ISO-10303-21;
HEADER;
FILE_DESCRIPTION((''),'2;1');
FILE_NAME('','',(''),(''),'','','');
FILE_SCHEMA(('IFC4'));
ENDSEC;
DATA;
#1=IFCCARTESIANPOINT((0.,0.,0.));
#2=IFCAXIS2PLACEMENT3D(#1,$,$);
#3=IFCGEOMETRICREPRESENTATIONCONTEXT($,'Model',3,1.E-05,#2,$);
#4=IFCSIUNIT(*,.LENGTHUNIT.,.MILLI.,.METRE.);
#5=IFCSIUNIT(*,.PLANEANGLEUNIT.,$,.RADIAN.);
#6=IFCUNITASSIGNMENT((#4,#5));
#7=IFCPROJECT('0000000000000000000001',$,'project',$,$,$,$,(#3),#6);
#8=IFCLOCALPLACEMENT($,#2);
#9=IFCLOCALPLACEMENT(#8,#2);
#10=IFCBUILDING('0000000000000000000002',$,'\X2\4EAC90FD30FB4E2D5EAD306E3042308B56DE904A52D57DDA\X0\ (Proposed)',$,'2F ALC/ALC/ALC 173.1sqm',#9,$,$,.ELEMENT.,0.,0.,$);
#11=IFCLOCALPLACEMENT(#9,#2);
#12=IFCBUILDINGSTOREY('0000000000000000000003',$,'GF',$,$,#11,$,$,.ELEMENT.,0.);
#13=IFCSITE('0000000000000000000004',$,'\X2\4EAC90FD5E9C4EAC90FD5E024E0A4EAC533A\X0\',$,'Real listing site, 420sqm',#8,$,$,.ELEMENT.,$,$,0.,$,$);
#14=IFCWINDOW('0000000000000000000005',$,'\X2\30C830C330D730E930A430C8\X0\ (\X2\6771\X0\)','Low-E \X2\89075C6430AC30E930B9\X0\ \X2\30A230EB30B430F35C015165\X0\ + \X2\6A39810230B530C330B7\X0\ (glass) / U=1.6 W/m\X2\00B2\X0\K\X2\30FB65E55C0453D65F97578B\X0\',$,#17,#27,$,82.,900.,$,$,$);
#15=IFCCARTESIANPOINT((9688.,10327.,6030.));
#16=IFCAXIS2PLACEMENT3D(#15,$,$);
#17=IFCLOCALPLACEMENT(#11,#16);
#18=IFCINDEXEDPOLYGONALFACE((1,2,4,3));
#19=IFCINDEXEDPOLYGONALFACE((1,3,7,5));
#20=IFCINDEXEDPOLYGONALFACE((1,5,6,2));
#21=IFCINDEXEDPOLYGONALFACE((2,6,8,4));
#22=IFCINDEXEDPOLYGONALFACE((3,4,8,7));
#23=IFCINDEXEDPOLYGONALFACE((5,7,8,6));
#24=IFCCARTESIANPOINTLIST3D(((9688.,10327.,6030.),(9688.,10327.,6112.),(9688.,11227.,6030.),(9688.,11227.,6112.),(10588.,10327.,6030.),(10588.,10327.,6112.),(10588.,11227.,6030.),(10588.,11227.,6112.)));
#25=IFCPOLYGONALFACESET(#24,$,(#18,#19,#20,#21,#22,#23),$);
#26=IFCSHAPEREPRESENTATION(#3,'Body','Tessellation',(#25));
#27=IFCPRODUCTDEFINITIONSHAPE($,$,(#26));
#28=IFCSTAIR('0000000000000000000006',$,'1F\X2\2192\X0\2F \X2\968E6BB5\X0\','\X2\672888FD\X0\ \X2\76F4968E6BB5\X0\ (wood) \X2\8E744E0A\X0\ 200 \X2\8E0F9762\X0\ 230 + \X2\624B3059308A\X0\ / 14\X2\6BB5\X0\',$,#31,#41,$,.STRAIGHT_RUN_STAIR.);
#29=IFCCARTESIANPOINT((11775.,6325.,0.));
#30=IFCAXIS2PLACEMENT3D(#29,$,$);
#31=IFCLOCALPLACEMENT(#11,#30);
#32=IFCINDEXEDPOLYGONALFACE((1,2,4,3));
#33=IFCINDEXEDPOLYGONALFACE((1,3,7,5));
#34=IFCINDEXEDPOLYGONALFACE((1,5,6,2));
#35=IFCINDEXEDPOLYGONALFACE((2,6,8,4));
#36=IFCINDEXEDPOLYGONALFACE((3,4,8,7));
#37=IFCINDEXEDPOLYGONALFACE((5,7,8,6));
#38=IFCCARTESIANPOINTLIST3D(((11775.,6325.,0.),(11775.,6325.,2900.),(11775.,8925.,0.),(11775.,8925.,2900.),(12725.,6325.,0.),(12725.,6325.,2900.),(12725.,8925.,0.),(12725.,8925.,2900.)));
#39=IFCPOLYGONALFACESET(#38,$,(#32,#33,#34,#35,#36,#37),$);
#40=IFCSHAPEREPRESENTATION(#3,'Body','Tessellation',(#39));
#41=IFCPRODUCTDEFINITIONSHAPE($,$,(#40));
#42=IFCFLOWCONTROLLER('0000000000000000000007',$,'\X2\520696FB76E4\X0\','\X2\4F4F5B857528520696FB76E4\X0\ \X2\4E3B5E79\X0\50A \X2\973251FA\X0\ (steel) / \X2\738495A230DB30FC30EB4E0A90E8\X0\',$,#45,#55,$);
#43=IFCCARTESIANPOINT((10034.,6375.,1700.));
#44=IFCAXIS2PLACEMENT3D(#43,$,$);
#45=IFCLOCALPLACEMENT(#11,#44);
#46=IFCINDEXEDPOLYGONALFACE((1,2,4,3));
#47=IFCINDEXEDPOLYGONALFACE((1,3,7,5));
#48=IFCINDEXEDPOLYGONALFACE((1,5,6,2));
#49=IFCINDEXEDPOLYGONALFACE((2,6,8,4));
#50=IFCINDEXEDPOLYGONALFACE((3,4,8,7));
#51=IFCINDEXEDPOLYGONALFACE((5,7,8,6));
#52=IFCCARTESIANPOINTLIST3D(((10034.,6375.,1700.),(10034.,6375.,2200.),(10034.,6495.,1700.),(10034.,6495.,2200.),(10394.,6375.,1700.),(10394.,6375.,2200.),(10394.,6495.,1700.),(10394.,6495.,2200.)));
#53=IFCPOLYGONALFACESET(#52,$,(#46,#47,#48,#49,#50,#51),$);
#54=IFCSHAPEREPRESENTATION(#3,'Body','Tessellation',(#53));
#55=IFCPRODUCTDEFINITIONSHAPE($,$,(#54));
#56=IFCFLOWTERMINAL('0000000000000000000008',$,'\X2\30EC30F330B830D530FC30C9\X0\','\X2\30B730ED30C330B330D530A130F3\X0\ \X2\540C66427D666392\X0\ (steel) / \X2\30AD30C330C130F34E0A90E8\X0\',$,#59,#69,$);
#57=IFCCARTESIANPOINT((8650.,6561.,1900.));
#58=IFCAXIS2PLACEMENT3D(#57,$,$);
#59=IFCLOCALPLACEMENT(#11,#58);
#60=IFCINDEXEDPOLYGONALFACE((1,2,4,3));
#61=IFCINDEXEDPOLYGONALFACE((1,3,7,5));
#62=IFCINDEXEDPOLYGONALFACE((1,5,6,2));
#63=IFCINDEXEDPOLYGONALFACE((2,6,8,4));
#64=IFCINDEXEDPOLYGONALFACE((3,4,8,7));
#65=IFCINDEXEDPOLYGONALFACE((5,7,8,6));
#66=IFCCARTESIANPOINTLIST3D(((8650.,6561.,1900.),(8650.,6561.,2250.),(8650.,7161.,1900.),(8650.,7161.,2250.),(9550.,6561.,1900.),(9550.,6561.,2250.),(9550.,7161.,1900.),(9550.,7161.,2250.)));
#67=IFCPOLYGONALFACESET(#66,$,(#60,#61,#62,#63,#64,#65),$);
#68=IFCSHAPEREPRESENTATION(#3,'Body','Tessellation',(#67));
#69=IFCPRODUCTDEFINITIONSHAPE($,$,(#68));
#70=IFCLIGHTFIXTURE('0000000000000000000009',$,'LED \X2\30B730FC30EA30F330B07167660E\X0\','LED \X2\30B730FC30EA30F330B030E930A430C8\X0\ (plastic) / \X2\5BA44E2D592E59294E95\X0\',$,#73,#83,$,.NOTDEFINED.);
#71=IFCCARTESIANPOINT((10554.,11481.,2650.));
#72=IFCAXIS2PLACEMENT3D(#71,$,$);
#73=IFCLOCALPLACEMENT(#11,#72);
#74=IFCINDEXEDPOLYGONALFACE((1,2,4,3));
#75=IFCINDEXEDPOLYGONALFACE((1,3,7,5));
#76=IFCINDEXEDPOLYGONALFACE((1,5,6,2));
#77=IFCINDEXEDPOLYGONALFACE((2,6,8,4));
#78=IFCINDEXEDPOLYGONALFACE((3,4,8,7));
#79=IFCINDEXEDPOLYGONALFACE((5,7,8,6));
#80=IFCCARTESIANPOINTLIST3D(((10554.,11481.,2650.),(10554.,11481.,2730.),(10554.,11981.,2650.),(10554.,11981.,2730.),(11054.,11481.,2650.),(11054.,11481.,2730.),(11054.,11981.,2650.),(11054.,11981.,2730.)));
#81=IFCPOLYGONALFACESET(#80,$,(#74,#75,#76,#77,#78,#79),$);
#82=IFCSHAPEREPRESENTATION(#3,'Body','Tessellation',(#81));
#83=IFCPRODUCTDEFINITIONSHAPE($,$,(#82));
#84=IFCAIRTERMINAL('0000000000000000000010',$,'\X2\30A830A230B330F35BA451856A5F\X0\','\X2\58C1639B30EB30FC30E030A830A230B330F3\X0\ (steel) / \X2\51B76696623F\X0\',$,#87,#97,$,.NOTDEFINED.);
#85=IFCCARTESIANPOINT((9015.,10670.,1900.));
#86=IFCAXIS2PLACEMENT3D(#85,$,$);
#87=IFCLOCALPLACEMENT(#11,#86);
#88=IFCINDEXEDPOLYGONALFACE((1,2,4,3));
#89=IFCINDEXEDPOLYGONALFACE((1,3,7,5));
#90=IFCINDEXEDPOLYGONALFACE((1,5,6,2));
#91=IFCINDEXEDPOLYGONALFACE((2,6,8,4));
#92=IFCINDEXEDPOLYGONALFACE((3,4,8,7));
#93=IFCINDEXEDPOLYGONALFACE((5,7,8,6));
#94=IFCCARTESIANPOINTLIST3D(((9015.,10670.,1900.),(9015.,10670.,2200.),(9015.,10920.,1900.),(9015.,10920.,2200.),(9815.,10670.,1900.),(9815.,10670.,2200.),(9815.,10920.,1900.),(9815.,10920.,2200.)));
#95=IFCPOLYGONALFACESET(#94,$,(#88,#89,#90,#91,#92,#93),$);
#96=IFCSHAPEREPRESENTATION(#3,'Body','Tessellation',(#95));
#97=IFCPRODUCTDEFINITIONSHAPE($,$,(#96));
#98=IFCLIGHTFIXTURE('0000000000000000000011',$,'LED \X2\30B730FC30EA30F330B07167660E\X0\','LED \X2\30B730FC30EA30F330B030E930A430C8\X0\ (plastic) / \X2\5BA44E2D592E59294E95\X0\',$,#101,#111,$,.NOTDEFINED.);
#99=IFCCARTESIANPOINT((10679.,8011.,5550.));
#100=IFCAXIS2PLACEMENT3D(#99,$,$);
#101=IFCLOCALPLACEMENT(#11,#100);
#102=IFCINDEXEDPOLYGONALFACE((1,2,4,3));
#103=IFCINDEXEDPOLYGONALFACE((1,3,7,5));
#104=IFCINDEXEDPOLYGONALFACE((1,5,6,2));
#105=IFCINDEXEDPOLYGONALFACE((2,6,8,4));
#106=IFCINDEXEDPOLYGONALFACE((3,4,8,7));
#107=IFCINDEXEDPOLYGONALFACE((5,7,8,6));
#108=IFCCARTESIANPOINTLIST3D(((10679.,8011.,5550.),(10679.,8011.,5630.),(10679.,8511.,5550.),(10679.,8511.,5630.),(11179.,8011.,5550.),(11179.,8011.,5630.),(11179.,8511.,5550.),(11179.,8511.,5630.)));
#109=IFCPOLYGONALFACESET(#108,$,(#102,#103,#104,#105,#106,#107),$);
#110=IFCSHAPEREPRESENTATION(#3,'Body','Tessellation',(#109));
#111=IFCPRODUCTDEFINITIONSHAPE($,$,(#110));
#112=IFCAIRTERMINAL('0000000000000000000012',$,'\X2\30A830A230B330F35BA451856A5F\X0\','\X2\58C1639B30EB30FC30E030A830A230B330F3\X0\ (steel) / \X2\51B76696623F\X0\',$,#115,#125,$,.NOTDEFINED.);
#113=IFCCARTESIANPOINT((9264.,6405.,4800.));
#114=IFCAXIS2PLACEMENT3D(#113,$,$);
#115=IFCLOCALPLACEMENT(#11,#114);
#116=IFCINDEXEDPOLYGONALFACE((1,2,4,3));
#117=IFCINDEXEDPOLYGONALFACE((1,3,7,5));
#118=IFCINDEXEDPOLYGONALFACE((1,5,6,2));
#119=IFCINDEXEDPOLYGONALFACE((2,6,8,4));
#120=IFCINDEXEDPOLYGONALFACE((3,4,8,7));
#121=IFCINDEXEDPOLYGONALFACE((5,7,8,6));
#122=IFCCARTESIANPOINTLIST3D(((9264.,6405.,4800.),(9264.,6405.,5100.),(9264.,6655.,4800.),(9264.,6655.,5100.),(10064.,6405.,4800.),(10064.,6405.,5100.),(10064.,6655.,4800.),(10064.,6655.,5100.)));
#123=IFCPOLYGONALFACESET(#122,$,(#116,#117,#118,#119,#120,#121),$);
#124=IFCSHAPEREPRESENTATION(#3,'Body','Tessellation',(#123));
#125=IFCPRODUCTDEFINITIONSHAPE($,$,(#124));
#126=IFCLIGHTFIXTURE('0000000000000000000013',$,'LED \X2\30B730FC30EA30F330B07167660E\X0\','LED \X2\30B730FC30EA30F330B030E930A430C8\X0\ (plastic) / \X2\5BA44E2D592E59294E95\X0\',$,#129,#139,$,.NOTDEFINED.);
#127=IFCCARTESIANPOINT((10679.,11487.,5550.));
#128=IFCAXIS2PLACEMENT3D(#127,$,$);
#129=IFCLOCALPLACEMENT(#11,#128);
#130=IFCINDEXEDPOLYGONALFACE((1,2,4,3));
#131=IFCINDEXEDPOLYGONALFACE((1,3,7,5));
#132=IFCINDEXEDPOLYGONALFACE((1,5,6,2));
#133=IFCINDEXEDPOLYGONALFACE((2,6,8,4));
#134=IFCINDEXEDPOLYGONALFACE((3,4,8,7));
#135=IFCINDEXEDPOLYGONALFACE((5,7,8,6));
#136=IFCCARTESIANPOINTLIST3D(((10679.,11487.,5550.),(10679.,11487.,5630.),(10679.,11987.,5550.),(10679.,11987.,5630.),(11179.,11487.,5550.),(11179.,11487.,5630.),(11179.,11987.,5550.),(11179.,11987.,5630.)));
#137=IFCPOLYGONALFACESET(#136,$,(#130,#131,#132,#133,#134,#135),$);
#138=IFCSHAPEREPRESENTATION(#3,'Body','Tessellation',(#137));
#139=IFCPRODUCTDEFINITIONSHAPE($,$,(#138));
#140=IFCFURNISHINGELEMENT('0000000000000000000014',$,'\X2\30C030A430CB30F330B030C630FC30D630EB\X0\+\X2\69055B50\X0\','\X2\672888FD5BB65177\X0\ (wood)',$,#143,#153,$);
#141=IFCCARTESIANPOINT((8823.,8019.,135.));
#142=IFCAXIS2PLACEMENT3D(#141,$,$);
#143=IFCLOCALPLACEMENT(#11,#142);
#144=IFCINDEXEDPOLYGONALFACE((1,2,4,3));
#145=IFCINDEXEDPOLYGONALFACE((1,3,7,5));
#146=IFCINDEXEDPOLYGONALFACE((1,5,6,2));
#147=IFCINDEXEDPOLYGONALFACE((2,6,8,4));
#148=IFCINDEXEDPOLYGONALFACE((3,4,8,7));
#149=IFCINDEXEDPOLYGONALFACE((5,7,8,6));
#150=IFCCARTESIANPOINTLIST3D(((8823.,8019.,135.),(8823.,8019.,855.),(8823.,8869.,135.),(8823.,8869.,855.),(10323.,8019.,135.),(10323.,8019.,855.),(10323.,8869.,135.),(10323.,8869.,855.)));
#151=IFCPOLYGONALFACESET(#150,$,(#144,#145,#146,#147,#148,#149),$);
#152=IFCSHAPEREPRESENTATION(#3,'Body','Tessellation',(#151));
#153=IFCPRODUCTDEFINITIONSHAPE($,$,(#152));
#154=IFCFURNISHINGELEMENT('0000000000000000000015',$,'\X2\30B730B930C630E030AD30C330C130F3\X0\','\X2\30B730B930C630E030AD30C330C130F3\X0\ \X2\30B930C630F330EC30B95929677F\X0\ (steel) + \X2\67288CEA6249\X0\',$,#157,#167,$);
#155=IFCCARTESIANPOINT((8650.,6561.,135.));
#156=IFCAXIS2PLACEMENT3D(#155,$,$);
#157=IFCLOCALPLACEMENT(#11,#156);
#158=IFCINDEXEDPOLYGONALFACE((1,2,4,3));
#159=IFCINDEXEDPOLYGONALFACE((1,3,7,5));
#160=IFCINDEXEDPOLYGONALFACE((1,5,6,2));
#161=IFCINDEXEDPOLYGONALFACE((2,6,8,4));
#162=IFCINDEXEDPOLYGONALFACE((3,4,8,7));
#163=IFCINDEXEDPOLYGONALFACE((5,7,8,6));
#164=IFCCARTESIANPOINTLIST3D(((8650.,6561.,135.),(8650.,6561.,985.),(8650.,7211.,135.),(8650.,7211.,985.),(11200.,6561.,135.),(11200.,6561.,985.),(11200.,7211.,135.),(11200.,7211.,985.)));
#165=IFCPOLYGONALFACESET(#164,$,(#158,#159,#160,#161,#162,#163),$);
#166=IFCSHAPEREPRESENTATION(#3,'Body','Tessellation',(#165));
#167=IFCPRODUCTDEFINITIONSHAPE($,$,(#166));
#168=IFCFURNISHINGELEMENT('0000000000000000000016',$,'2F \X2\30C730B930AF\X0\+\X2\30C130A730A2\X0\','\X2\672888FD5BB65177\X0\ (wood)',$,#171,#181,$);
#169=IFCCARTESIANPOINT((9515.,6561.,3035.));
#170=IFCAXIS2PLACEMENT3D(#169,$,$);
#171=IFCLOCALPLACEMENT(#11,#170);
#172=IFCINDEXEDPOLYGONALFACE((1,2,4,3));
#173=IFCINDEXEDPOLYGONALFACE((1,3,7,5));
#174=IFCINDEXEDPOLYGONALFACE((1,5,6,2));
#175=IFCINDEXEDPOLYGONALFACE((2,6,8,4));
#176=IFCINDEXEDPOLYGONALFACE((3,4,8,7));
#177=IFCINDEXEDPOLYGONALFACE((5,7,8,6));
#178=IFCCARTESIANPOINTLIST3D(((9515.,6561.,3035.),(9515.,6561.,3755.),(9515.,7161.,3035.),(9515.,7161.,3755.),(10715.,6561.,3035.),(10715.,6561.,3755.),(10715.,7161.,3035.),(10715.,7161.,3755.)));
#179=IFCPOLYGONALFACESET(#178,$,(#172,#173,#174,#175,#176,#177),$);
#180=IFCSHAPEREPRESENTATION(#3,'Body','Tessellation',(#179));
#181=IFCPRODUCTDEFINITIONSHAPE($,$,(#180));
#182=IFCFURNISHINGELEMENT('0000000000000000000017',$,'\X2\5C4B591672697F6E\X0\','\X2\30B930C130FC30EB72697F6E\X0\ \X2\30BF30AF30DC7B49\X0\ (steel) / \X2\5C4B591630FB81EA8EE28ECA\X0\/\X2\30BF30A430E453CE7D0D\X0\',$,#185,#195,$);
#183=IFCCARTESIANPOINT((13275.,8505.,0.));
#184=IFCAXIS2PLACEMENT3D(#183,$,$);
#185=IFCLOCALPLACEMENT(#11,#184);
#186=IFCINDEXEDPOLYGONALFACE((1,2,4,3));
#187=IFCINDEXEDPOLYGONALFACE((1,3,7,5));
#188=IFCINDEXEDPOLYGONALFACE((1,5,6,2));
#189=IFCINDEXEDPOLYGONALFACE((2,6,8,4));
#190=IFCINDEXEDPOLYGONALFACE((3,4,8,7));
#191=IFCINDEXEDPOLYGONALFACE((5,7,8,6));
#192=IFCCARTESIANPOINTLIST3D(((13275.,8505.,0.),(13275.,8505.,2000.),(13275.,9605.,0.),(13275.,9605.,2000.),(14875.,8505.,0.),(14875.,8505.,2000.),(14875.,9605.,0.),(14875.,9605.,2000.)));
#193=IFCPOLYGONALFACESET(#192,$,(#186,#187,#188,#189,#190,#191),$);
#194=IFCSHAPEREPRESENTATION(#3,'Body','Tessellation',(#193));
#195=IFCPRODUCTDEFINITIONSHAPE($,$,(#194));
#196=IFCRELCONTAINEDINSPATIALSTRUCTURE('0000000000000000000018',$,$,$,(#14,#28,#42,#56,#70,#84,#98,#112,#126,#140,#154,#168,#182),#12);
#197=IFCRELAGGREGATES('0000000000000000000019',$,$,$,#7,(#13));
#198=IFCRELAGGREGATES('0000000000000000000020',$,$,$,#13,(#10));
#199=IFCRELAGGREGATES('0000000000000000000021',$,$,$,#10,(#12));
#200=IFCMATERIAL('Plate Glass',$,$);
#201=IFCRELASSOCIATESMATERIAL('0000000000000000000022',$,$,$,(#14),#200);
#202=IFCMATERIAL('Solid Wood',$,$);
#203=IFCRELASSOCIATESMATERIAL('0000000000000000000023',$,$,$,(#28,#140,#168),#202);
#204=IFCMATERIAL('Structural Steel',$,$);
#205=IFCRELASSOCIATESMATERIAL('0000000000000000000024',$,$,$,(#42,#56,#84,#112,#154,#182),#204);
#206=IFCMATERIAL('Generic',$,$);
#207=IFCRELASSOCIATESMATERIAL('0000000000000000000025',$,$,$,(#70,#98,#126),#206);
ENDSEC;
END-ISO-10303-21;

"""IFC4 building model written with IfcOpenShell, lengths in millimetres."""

from ifc_helpers import new_model, si_unit, frame, frame_2d, origin, place, context, project, spatial, rectangle, extrude, material, element, save


model = new_model("IFC4")

# Units and contexts
model_context = context("Model", 3, precision=1e-05, world=origin())
ifc_project = project(units=[si_unit("LENGTHUNIT", "METRE", prefix="MILLI"), si_unit("PLANEANGLEUNIT", "RADIAN")], contexts=[model_context])

# Site, building, storey
site_placement = place(None, origin())
site = spatial("IfcSite", under=ifc_project, at=site_placement, Name="京都府京都市上京区", ObjectType="Real listing site, 420sqm", CompositionType="ELEMENT", RefElevation=0.0)
building_placement = place(site_placement, origin())
building = spatial("IfcBuilding", under=site, at=building_placement, Name="京都・中庭のある回遊動線 (Proposed)", ObjectType="2F ALC/ALC/ALC 173.1sqm", CompositionType="ELEMENT", ElevationOfRefHeight=0.0, ElevationOfTerrain=0.0)
storey_placement = place(building_placement, origin())
storey = spatial("IfcBuildingStorey", under=building, at=storey_placement, Name="GF", CompositionType="ELEMENT", Elevation=0.0)

# Shared definitions
ifc_material_1 = material(Name="Solid Wood")

# Window
ifc_material_2 = material(Name="Plate Glass")
window_placement = place(storey_placement, frame((9688.0, 10327.0, 6030.0)))
element("IfcWindow", 1, at=window_placement, inside=storey, material=ifc_material_2, Name="トップライト (東)", Description="Low-E 複層ガラス アルゴン封入 + 樹脂サッシ (glass) / U=1.6 W/m²K・日射取得型", OverallHeight=82.0, OverallWidth=900.0, context=model_context, shape_type="SweptSolid", body=[
    extrude(rectangle(XDim=900.0, YDim=900.0, at=frame_2d((450.0, 450.0))), frame((9688.0, 10327.0, 6030.0)), (0.0, 0.0, 1.0), 82.0),
])

# Stair
stair_placement = place(storey_placement, frame((11775.0, 6325.0, 0.0)))
element("IfcStair", 2, at=stair_placement, inside=storey, material=ifc_material_1, Name="1F→2F 階段", Description="木製 直階段 (wood) 蹴上 200 踏面 230 + 手すり / 14段", PredefinedType="STRAIGHT_RUN_STAIR", context=model_context, shape_type="SweptSolid", body=[
    extrude(rectangle(XDim=950.0, YDim=2600.0, at=frame_2d((475.0, 1300.0))), frame((11775.0, 6325.0, 0.0)), (0.0, 0.0, 1.0), 2900.0),
])

# Flow controller
ifc_material_3 = material(Name="Structural Steel")
flow_controller_placement = place(storey_placement, frame((10034.0, 6375.0, 1700.0)))
element("IfcFlowController", 3, at=flow_controller_placement, inside=storey, material=ifc_material_3, Name="分電盤", Description="住宅用分電盤 主幹50A 露出 (steel) / 玄関ホール上部", context=model_context, shape_type="SweptSolid", body=[
    extrude(rectangle(XDim=360.0, YDim=120.0, at=frame_2d((180.0, 60.0))), frame((10034.0, 6375.0, 1700.0)), (0.0, 0.0, 1.0), 500.0),
])

# Flow terminal
flow_terminal_placement = place(storey_placement, frame((8650.0, 6561.0, 1900.0)))
element("IfcFlowTerminal", 4, at=flow_terminal_placement, inside=storey, material=ifc_material_3, Name="レンジフード", Description="シロッコファン 同時給排 (steel) / キッチン上部", context=model_context, shape_type="SweptSolid", body=[
    extrude(rectangle(XDim=900.0, YDim=600.0, at=frame_2d((450.0, 300.0))), frame((8650.0, 6561.0, 1900.0)), (0.0, 0.0, 1.0), 350.0),
])

# Light fixture
ifc_material_4 = material(Name="Generic")
light_fixture_1_placement = place(storey_placement, frame((10554.0, 11481.0, 2650.0)))
element("IfcLightFixture", 5, at=light_fixture_1_placement, inside=storey, material=ifc_material_4, Name="LED シーリング照明", Description="LED シーリングライト (plastic) / 室中央天井", PredefinedType="NOTDEFINED", context=model_context, shape_type="SweptSolid", body=[
    extrude(rectangle(XDim=500.0, YDim=500.0, at=frame_2d((250.0, 250.0))), frame((10554.0, 11481.0, 2650.0)), (0.0, 0.0, 1.0), 80.0),
])

# Air terminal
air_terminal_1_placement = place(storey_placement, frame((9015.0, 10670.0, 1900.0)))
element("IfcAirTerminal", 6, at=air_terminal_1_placement, inside=storey, material=ifc_material_3, Name="エアコン室内機", Description="壁掛ルームエアコン (steel) / 冷暖房", PredefinedType="NOTDEFINED", context=model_context, shape_type="SweptSolid", body=[
    extrude(rectangle(XDim=800.0, YDim=250.0, at=frame_2d((400.0, 125.0))), frame((9015.0, 10670.0, 1900.0)), (0.0, 0.0, 1.0), 300.0),
])

# Light fixture
light_fixture_2_placement = place(storey_placement, frame((10679.0, 8011.0, 5550.0)))
element("IfcLightFixture", 7, at=light_fixture_2_placement, inside=storey, material=ifc_material_4, Name="LED シーリング照明", Description="LED シーリングライト (plastic) / 室中央天井", PredefinedType="NOTDEFINED", context=model_context, shape_type="SweptSolid", body=[
    extrude(rectangle(XDim=500.0, YDim=500.0, at=frame_2d((250.0, 250.0))), frame((10679.0, 8011.0, 5550.0)), (0.0, 0.0, 1.0), 80.0),
])

# Air terminal
air_terminal_2_placement = place(storey_placement, frame((9264.0, 6405.0, 4800.0)))
element("IfcAirTerminal", 8, at=air_terminal_2_placement, inside=storey, material=ifc_material_3, Name="エアコン室内機", Description="壁掛ルームエアコン (steel) / 冷暖房", PredefinedType="NOTDEFINED", context=model_context, shape_type="SweptSolid", body=[
    extrude(rectangle(XDim=800.0, YDim=250.0, at=frame_2d((400.0, 125.0))), frame((9264.0, 6405.0, 4800.0)), (0.0, 0.0, 1.0), 300.0),
])

# Light fixture
light_fixture_3_placement = place(storey_placement, frame((10679.0, 11487.0, 5550.0)))
element("IfcLightFixture", 9, at=light_fixture_3_placement, inside=storey, material=ifc_material_4, Name="LED シーリング照明", Description="LED シーリングライト (plastic) / 室中央天井", PredefinedType="NOTDEFINED", context=model_context, shape_type="SweptSolid", body=[
    extrude(rectangle(XDim=500.0, YDim=500.0, at=frame_2d((250.0, 250.0))), frame((10679.0, 11487.0, 5550.0)), (0.0, 0.0, 1.0), 80.0),
])

# Furnishing elements
furnishing_1_placement = place(storey_placement, frame((8823.0, 8019.0, 135.0)))
element("IfcFurnishingElement", 10, at=furnishing_1_placement, inside=storey, material=ifc_material_1, Name="ダイニングテーブル+椅子", Description="木製家具 (wood)", context=model_context, shape_type="SweptSolid", body=[
    extrude(rectangle(XDim=1500.0, YDim=850.0, at=frame_2d((750.0, 425.0))), frame((8823.0, 8019.0, 135.0)), (0.0, 0.0, 1.0), 720.0),
])
furnishing_2_placement = place(storey_placement, frame((8650.0, 6561.0, 135.0)))
element("IfcFurnishingElement", 11, at=furnishing_2_placement, inside=storey, material=ifc_material_3, Name="システムキッチン", Description="システムキッチン ステンレス天板 (steel) + 木質扉", context=model_context, shape_type="SweptSolid", body=[
    extrude(rectangle(XDim=2550.0, YDim=650.0, at=frame_2d((1275.0, 325.0))), frame((8650.0, 6561.0, 135.0)), (0.0, 0.0, 1.0), 850.0),
])
furnishing_3_placement = place(storey_placement, frame((9515.0, 6561.0, 3035.0)))
element("IfcFurnishingElement", 12, at=furnishing_3_placement, inside=storey, material=ifc_material_1, Name="2F デスク+チェア", Description="木製家具 (wood)", context=model_context, shape_type="SweptSolid", body=[
    extrude(rectangle(XDim=1200.0, YDim=600.0, at=frame_2d((600.0, 300.0))), frame((9515.0, 6561.0, 3035.0)), (0.0, 0.0, 1.0), 720.0),
])
furnishing_4_placement = place(storey_placement, frame((13275.0, 8505.0, 0.0)))
element("IfcFurnishingElement", 13, at=furnishing_4_placement, inside=storey, material=ifc_material_3, Name="屋外物置", Description="スチール物置 タクボ等 (steel) / 屋外・自転車/タイヤ収納", context=model_context, shape_type="SweptSolid", body=[
    extrude(rectangle(XDim=1600.0, YDim=1100.0, at=frame_2d((800.0, 550.0))), frame((13275.0, 8505.0, 0.0)), (0.0, 0.0, 1.0), 2000.0),
])

save(model, "model.ifc")
